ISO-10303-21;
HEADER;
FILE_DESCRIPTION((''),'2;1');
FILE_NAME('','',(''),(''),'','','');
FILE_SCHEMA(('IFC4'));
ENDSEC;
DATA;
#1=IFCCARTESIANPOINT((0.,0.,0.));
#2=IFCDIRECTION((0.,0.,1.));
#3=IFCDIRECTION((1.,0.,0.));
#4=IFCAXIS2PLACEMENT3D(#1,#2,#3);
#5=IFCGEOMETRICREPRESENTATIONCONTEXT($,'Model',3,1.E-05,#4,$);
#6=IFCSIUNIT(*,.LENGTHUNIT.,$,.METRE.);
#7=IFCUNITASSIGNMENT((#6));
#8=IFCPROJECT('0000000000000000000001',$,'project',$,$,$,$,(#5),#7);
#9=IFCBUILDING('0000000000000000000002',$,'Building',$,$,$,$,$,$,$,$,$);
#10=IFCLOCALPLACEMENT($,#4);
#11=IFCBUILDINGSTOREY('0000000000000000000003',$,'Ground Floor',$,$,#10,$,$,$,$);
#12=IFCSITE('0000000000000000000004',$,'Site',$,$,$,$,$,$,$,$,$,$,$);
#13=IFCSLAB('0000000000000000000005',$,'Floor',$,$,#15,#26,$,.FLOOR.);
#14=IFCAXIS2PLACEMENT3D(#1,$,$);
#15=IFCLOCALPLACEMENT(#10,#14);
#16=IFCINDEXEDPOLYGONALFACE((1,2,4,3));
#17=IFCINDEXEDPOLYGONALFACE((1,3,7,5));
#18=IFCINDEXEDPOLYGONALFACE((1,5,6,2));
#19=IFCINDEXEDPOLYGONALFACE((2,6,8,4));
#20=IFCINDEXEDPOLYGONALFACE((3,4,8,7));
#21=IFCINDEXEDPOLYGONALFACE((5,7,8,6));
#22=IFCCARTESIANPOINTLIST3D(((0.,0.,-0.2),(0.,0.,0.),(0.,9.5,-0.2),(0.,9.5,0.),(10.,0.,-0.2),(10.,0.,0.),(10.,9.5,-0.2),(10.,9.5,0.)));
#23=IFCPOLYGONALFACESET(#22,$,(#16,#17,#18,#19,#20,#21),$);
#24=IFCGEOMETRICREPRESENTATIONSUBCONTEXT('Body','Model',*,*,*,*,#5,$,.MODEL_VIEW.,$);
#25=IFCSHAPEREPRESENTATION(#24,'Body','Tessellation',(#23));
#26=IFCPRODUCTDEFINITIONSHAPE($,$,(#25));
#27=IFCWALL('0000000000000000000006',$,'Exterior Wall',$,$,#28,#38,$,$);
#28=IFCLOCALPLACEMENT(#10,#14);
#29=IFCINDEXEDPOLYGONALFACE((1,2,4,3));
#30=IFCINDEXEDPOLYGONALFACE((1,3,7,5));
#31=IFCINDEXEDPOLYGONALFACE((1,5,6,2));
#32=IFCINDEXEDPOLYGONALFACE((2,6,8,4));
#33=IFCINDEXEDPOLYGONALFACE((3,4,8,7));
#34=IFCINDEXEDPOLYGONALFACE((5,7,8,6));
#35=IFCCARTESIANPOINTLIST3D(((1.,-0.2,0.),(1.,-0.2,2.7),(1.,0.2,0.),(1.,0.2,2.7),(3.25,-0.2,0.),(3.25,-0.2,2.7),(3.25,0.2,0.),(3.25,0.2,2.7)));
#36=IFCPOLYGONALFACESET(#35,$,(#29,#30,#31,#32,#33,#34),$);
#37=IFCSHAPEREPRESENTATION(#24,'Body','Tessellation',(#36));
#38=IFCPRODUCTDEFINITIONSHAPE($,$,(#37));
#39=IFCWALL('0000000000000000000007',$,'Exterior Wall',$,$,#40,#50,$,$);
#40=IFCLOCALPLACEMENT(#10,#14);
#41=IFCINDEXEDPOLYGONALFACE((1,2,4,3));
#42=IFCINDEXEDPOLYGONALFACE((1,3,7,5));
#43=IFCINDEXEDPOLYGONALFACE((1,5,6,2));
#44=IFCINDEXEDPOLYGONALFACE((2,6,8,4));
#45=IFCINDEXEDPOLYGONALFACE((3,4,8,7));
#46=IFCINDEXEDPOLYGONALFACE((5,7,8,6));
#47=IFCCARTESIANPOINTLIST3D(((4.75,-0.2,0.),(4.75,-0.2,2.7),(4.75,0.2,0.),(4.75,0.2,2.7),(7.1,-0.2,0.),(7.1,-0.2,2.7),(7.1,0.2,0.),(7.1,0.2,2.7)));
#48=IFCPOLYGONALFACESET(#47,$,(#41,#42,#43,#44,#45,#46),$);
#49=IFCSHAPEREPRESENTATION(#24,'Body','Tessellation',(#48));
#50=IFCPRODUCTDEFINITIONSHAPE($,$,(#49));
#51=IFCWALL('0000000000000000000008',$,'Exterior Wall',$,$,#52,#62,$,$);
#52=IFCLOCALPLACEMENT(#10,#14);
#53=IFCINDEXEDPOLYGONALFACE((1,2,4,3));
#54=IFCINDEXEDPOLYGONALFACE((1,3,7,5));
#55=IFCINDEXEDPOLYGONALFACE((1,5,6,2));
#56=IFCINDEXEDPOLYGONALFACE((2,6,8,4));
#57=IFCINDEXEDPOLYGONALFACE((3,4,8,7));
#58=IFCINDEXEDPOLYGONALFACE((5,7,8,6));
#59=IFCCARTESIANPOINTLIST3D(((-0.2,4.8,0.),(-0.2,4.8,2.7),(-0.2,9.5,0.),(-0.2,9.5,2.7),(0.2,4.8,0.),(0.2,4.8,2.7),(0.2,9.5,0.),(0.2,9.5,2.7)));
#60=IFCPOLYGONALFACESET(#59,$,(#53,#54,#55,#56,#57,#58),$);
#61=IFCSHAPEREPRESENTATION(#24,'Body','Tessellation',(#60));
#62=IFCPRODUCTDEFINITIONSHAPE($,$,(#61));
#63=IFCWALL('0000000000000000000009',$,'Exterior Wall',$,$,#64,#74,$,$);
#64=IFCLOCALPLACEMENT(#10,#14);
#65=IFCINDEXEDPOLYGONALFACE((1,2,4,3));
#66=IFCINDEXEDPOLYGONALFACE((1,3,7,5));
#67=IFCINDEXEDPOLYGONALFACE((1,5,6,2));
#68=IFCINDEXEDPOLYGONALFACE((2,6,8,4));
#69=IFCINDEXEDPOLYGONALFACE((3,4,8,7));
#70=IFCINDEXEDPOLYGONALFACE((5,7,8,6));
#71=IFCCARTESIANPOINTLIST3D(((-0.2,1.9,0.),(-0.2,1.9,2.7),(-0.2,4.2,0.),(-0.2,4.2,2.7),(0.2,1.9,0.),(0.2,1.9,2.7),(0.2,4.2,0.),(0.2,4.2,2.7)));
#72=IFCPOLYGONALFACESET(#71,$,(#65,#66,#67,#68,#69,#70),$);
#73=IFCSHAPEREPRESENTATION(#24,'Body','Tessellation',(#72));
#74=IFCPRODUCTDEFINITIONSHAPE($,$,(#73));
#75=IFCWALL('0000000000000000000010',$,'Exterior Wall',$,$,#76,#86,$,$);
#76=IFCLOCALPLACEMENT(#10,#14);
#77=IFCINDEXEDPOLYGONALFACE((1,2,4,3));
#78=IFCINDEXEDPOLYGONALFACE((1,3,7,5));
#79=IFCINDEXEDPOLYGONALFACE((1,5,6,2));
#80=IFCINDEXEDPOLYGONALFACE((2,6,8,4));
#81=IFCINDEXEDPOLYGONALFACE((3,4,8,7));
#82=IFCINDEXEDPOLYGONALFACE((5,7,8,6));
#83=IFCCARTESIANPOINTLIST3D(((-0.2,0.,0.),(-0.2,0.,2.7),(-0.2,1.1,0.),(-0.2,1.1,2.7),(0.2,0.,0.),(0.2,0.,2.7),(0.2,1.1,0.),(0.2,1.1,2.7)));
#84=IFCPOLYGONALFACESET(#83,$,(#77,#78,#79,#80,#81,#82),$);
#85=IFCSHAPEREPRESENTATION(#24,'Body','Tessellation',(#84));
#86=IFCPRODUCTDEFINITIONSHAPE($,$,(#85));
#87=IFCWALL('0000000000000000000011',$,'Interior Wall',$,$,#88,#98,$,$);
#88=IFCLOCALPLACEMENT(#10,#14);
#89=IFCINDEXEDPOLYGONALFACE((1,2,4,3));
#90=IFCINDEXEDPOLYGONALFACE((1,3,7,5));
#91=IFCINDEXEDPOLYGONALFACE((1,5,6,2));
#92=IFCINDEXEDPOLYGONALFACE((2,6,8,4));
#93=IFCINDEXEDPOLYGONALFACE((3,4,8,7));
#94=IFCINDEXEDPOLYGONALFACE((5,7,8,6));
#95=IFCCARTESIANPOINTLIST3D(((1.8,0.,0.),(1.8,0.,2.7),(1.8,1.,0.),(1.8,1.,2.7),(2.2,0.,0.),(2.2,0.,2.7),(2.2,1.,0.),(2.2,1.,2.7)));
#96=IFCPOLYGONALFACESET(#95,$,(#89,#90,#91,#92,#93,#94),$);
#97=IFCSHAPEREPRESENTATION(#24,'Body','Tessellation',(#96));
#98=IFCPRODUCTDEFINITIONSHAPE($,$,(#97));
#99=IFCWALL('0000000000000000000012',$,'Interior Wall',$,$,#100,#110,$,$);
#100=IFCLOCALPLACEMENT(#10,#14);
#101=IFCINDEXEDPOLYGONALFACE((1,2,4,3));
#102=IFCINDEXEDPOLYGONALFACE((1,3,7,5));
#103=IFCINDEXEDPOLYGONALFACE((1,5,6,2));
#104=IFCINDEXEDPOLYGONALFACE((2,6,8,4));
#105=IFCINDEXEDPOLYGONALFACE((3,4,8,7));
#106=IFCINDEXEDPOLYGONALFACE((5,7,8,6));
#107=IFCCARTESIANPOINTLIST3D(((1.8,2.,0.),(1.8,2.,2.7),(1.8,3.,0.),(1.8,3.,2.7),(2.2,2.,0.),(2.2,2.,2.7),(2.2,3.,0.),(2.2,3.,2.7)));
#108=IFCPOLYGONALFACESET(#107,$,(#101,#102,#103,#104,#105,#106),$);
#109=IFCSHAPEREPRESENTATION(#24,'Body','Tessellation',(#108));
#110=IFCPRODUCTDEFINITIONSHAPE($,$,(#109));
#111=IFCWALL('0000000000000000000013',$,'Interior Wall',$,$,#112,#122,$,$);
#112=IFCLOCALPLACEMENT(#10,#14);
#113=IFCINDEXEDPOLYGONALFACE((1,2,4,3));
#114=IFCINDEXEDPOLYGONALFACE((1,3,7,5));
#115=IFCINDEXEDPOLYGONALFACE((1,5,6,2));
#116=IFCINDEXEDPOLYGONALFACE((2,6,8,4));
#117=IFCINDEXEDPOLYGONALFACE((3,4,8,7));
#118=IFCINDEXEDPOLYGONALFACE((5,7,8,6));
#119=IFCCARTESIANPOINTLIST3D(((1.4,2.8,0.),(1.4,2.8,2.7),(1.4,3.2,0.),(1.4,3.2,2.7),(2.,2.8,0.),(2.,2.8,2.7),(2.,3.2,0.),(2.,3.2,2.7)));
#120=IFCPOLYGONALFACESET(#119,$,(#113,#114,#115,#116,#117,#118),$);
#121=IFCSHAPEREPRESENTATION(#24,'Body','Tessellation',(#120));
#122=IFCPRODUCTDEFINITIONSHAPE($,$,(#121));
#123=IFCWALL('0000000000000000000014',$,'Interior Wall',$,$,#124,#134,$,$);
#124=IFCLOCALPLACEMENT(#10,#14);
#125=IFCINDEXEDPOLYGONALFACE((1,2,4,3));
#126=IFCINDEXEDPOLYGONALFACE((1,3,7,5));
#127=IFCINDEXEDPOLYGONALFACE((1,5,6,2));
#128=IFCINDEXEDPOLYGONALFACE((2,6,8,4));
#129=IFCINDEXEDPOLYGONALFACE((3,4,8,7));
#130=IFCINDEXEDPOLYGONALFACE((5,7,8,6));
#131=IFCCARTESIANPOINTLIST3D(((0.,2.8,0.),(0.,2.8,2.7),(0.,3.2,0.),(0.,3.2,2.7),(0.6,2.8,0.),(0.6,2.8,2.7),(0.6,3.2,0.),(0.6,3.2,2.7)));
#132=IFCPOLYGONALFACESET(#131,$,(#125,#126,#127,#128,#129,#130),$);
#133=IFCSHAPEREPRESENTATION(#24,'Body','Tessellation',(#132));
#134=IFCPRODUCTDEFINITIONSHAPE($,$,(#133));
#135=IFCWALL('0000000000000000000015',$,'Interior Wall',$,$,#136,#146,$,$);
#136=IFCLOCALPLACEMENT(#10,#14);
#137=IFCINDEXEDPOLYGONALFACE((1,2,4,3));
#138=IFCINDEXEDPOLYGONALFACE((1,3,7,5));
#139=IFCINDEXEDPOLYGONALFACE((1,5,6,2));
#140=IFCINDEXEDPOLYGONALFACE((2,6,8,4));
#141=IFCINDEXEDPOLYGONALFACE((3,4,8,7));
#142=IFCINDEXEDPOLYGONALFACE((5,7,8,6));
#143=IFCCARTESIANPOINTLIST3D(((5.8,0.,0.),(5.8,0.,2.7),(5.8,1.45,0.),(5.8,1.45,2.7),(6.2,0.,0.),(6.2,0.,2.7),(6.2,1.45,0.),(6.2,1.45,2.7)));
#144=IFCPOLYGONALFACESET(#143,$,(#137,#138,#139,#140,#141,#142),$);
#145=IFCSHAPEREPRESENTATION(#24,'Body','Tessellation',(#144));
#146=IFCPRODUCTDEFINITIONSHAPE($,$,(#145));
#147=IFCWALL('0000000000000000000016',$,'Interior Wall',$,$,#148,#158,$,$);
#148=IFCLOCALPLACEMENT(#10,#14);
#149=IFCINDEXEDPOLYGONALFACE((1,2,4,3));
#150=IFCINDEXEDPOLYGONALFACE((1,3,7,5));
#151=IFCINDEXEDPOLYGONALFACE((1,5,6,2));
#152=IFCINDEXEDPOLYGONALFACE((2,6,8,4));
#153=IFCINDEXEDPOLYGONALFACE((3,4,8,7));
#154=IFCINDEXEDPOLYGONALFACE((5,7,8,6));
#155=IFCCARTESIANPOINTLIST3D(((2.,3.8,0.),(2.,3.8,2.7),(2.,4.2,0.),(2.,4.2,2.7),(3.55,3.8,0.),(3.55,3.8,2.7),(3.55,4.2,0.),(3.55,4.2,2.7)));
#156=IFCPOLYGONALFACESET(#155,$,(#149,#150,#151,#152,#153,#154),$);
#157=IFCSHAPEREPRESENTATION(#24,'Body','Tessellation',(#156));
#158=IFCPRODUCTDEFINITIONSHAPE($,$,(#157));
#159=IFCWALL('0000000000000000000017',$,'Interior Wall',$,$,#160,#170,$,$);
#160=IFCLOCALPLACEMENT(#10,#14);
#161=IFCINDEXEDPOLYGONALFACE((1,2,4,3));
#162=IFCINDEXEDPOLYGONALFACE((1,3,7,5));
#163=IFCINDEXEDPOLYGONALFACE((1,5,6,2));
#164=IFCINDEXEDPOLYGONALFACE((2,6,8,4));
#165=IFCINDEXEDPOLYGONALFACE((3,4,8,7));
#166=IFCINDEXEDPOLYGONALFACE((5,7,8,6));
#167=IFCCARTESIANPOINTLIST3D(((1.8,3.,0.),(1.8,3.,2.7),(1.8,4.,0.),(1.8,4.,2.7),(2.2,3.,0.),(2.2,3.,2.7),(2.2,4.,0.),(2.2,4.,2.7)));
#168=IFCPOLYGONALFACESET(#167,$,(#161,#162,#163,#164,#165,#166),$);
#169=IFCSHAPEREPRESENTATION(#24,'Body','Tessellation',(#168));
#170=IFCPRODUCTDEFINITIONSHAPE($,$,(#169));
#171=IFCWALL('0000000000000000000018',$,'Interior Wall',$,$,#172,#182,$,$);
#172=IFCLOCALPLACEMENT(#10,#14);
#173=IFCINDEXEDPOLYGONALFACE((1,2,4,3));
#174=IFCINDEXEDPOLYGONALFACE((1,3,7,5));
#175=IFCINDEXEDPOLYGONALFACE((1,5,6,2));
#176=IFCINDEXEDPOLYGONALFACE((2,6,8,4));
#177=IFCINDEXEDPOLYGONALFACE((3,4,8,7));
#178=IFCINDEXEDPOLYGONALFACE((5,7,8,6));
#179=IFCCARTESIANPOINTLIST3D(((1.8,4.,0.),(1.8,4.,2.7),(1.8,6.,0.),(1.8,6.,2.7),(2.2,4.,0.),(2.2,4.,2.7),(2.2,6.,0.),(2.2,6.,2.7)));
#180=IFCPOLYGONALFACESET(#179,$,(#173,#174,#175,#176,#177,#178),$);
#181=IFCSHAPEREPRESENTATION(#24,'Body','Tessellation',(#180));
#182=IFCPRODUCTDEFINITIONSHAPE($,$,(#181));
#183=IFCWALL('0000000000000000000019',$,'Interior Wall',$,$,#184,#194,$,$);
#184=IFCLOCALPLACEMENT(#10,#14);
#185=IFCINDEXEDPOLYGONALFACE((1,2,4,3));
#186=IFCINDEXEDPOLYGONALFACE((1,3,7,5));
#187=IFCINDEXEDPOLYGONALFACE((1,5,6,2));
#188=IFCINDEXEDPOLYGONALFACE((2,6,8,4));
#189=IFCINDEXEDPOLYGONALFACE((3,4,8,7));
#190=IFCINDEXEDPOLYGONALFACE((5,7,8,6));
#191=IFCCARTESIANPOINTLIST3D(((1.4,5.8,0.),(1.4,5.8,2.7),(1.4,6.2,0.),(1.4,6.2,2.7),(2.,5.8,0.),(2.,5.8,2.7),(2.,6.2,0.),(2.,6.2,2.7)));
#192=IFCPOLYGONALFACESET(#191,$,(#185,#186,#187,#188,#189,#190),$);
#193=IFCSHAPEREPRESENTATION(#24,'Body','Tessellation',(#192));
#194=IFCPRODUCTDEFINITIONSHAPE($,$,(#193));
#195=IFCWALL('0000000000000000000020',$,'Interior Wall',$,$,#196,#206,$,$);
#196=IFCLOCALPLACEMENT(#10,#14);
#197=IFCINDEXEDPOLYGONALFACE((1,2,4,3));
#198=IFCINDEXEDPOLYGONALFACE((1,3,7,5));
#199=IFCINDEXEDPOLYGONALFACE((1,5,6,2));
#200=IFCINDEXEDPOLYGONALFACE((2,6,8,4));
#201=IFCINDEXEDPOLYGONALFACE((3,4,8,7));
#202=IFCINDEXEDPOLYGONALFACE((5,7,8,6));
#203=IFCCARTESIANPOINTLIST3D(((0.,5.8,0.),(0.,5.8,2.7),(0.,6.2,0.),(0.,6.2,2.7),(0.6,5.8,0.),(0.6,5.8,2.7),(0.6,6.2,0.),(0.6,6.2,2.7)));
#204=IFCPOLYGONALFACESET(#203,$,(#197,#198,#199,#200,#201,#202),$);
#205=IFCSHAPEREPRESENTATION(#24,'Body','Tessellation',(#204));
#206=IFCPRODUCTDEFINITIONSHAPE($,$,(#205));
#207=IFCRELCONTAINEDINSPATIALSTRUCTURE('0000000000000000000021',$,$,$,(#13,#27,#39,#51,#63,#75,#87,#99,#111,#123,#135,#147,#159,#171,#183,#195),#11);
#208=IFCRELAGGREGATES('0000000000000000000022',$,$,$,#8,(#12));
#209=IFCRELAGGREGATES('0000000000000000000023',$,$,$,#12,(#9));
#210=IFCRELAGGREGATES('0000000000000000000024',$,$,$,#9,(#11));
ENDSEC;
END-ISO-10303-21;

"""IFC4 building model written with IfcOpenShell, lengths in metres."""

from ifc_helpers import new_model, si_unit, frame, origin_with_axes, place, context, subcontext, project, spatial, indexed_curve, outline, extrude, element, save


model = new_model("IFC4")

# Units and contexts
model_context = context("Model", 3, precision=1e-05, world=origin_with_axes())
body_context = subcontext(model_context, "Body", "Model", "MODEL_VIEW")
ifc_project = project(units=[si_unit("LENGTHUNIT", "METRE")], contexts=[model_context])

# Site, building, storey
site = spatial("IfcSite", under=ifc_project, Name="Site")
building = spatial("IfcBuilding", under=site, Name="Building")
storey_placement = place(None, origin_with_axes())
storey = spatial("IfcBuildingStorey", under=building, at=storey_placement, Name="Ground Floor")

# Slab
slab_placement = place(storey_placement, frame((0.0, 0.0, -0.2), z_axis=(0.0, 0.0, 1.0), x_axis=(1.0, 0.0, 0.0)))
element("IfcSlab", 1, at=slab_placement, inside=storey, Name="Floor", PredefinedType="FLOOR", context=body_context, shape_type="SweptSolid", body=[
    extrude(outline(indexed_curve([(0.0, 0.0), (10.0, 0.0), (10.0, 9.5), (0.0, 9.5)])), None, (0.0, 0.0, 1.0), 0.2),
])

# Walls
wall_1_placement = place(storey_placement, frame((1.0, 0.0, 0.0), z_axis=(0.0, 0.0, 1.0), x_axis=(1.0, 0.0, 0.0)))
element("IfcWall", 2, at=wall_1_placement, inside=storey, Name="Exterior Wall", context=body_context, shape_type="SweptSolid", body=[
    extrude(outline(indexed_curve([(0.0, 0.0), (0.0, 0.4), (2.25, 0.4), (2.25, 0.0), (0.0, 0.0)], self_intersect=False)), frame((0.0, -0.2, 0.0), z_axis=(0.0, 0.0, 1.0), x_axis=(1.0, 0.0, 0.0)), (0.0, 0.0, 1.0), 2.7),
])
wall_2_placement = place(storey_placement, frame((4.75, 0.0, 0.0), z_axis=(0.0, 0.0, 1.0), x_axis=(1.0, 0.0, 0.0)))
element("IfcWall", 3, at=wall_2_placement, inside=storey, Name="Exterior Wall", context=body_context, shape_type="SweptSolid", body=[
    extrude(outline(indexed_curve([(0.0, 0.0), (0.0, 0.4), (2.35, 0.4), (2.35, 0.0), (0.0, 0.0)], self_intersect=False)), frame((0.0, -0.2, 0.0), z_axis=(0.0, 0.0, 1.0), x_axis=(1.0, 0.0, 0.0)), (0.0, 0.0, 1.0), 2.7),
])
wall_3_placement = place(storey_placement, frame((0.0, 9.5, 0.0), z_axis=(0.0, 0.0, 1.0), x_axis=(0.0, -1.0, 0.0)))
element("IfcWall", 4, at=wall_3_placement, inside=storey, Name="Exterior Wall", context=body_context, shape_type="SweptSolid", body=[
    extrude(outline(indexed_curve([(0.0, 0.0), (0.0, 0.4), (4.7, 0.4), (4.7, 0.0), (0.0, 0.0)], self_intersect=False)), frame((0.0, -0.2, 0.0), z_axis=(0.0, 0.0, 1.0), x_axis=(1.0, 0.0, 0.0)), (0.0, 0.0, 1.0), 2.7),
])
wall_4_placement = place(storey_placement, frame((0.0, 4.2, 0.0), z_axis=(0.0, 0.0, 1.0), x_axis=(0.0, -1.0, 0.0)))
element("IfcWall", 5, at=wall_4_placement, inside=storey, Name="Exterior Wall", context=body_context, shape_type="SweptSolid", body=[
    extrude(outline(indexed_curve([(0.0, 0.0), (0.0, 0.4), (2.3, 0.4), (2.3, 0.0), (0.0, 0.0)], self_intersect=False)), frame((0.0, -0.2, 0.0), z_axis=(0.0, 0.0, 1.0), x_axis=(1.0, 0.0, 0.0)), (0.0, 0.0, 1.0), 2.7),
])
wall_5_placement = place(storey_placement, frame((0.0, 1.1, 0.0), z_axis=(0.0, 0.0, 1.0), x_axis=(0.0, -1.0, 0.0)))
element("IfcWall", 6, at=wall_5_placement, inside=storey, Name="Exterior Wall", context=body_context, shape_type="SweptSolid", body=[
    extrude(outline(indexed_curve([(0.0, 0.0), (0.0, 0.4), (1.1, 0.4), (1.1, 0.0), (0.0, 0.0)], self_intersect=False)), frame((0.0, -0.2, 0.0), z_axis=(0.0, 0.0, 1.0), x_axis=(1.0, 0.0, 0.0)), (0.0, 0.0, 1.0), 2.7),
])
for number, where, z_axis, x_axis, name in (
    (7, (2.0, 0.0, 0.0), (0.0, 0.0, 1.0), (0.0, 1.0, 0.0), "Interior Wall"),
    (8, (2.0, 2.0, 0.0), (0.0, 0.0, 1.0), (0.0, 1.0, 0.0), "Interior Wall"),
):
    element("IfcWall", number, at=place(storey_placement, frame(where, z_axis=z_axis, x_axis=x_axis)), inside=storey, Name=name, context=body_context, shape_type="SweptSolid", body=[
        extrude(outline(indexed_curve([(0.0, 0.0), (0.0, 0.4), (1.0, 0.4), (1.0, 0.0), (0.0, 0.0)], self_intersect=False)), frame((0.0, -0.2, 0.0), z_axis=(0.0, 0.0, 1.0), x_axis=(1.0, 0.0, 0.0)), (0.0, 0.0, 1.0), 2.7),
    ])
for number, where, z_axis, x_axis, name in (
    (9, (2.0, 3.0, 0.0), (0.0, 0.0, 1.0), (-1.0, 0.0, 0.0), "Interior Wall"),
    (10, (0.6, 3.0, 0.0), (0.0, 0.0, 1.0), (-1.0, 0.0, 0.0), "Interior Wall"),
):
    element("IfcWall", number, at=place(storey_placement, frame(where, z_axis=z_axis, x_axis=x_axis)), inside=storey, Name=name, context=body_context, shape_type="SweptSolid", body=[
        extrude(outline(indexed_curve([(0.0, 0.0), (0.0, 0.4), (0.6, 0.4), (0.6, 0.0), (0.0, 0.0)], self_intersect=False)), frame((0.0, -0.2, 0.0), z_axis=(0.0, 0.0, 1.0), x_axis=(1.0, 0.0, 0.0)), (0.0, 0.0, 1.0), 2.7),
    ])
wall_6_placement = place(storey_placement, frame((6.0, 0.0, 0.0), z_axis=(0.0, 0.0, 1.0), x_axis=(0.0, 1.0, 0.0)))
element("IfcWall", 11, at=wall_6_placement, inside=storey, Name="Interior Wall", context=body_context, shape_type="SweptSolid", body=[
    extrude(outline(indexed_curve([(0.0, 0.0), (0.0, 0.4), (1.45, 0.4), (1.45, 0.0), (0.0, 0.0)], self_intersect=False)), frame((0.0, -0.2, 0.0), z_axis=(0.0, 0.0, 1.0), x_axis=(1.0, 0.0, 0.0)), (0.0, 0.0, 1.0), 2.7),
])
wall_7_placement = place(storey_placement, frame((3.55, 4.0, 0.0), z_axis=(0.0, 0.0, 1.0), x_axis=(-1.0, 0.0, 0.0)))
element("IfcWall", 12, at=wall_7_placement, inside=storey, Name="Interior Wall", context=body_context, shape_type="SweptSolid", body=[
    extrude(outline(indexed_curve([(0.0, 0.0), (0.0, 0.4), (1.55, 0.4), (1.55, 0.0), (0.0, 0.0)], self_intersect=False)), frame((0.0, -0.2, 0.0), z_axis=(0.0, 0.0, 1.0), x_axis=(1.0, 0.0, 0.0)), (0.0, 0.0, 1.0), 2.7),
])
wall_8_placement = place(storey_placement, frame((2.0, 4.0, 0.0), z_axis=(0.0, 0.0, 1.0), x_axis=(0.0, -1.0, 0.0)))
element("IfcWall", 13, at=wall_8_placement, inside=storey, Name="Interior Wall", context=body_context, shape_type="SweptSolid", body=[
    extrude(outline(indexed_curve([(0.0, 0.0), (0.0, 0.4), (1.0, 0.4), (1.0, 0.0), (0.0, 0.0)], self_intersect=False)), frame((0.0, -0.2, 0.0), z_axis=(0.0, 0.0, 1.0), x_axis=(1.0, 0.0, 0.0)), (0.0, 0.0, 1.0), 2.7),
])
wall_9_placement = place(storey_placement, frame((2.0, 4.0, 0.0), z_axis=(0.0, 0.0, 1.0), x_axis=(0.0, 1.0, 0.0)))
element("IfcWall", 14, at=wall_9_placement, inside=storey, Name="Interior Wall", context=body_context, shape_type="SweptSolid", body=[
    extrude(outline(indexed_curve([(0.0, 0.0), (0.0, 0.4), (2.0, 0.4), (2.0, 0.0), (0.0, 0.0)], self_intersect=False)), frame((0.0, -0.2, 0.0), z_axis=(0.0, 0.0, 1.0), x_axis=(1.0, 0.0, 0.0)), (0.0, 0.0, 1.0), 2.7),
])
for number, where, z_axis, x_axis, name in (
    (15, (2.0, 6.0, 0.0), (0.0, 0.0, 1.0), (-1.0, 0.0, 0.0), "Interior Wall"),
    (16, (0.6, 6.0, 0.0), (0.0, 0.0, 1.0), (-1.0, 0.0, 0.0), "Interior Wall"),
):
    element("IfcWall", number, at=place(storey_placement, frame(where, z_axis=z_axis, x_axis=x_axis)), inside=storey, Name=name, context=body_context, shape_type="SweptSolid", body=[
        extrude(outline(indexed_curve([(0.0, 0.0), (0.0, 0.4), (0.6, 0.4), (0.6, 0.0), (0.0, 0.0)], self_intersect=False)), frame((0.0, -0.2, 0.0), z_axis=(0.0, 0.0, 1.0), x_axis=(1.0, 0.0, 0.0)), (0.0, 0.0, 1.0), 2.7),
    ])

save(model, "model.ifc")
